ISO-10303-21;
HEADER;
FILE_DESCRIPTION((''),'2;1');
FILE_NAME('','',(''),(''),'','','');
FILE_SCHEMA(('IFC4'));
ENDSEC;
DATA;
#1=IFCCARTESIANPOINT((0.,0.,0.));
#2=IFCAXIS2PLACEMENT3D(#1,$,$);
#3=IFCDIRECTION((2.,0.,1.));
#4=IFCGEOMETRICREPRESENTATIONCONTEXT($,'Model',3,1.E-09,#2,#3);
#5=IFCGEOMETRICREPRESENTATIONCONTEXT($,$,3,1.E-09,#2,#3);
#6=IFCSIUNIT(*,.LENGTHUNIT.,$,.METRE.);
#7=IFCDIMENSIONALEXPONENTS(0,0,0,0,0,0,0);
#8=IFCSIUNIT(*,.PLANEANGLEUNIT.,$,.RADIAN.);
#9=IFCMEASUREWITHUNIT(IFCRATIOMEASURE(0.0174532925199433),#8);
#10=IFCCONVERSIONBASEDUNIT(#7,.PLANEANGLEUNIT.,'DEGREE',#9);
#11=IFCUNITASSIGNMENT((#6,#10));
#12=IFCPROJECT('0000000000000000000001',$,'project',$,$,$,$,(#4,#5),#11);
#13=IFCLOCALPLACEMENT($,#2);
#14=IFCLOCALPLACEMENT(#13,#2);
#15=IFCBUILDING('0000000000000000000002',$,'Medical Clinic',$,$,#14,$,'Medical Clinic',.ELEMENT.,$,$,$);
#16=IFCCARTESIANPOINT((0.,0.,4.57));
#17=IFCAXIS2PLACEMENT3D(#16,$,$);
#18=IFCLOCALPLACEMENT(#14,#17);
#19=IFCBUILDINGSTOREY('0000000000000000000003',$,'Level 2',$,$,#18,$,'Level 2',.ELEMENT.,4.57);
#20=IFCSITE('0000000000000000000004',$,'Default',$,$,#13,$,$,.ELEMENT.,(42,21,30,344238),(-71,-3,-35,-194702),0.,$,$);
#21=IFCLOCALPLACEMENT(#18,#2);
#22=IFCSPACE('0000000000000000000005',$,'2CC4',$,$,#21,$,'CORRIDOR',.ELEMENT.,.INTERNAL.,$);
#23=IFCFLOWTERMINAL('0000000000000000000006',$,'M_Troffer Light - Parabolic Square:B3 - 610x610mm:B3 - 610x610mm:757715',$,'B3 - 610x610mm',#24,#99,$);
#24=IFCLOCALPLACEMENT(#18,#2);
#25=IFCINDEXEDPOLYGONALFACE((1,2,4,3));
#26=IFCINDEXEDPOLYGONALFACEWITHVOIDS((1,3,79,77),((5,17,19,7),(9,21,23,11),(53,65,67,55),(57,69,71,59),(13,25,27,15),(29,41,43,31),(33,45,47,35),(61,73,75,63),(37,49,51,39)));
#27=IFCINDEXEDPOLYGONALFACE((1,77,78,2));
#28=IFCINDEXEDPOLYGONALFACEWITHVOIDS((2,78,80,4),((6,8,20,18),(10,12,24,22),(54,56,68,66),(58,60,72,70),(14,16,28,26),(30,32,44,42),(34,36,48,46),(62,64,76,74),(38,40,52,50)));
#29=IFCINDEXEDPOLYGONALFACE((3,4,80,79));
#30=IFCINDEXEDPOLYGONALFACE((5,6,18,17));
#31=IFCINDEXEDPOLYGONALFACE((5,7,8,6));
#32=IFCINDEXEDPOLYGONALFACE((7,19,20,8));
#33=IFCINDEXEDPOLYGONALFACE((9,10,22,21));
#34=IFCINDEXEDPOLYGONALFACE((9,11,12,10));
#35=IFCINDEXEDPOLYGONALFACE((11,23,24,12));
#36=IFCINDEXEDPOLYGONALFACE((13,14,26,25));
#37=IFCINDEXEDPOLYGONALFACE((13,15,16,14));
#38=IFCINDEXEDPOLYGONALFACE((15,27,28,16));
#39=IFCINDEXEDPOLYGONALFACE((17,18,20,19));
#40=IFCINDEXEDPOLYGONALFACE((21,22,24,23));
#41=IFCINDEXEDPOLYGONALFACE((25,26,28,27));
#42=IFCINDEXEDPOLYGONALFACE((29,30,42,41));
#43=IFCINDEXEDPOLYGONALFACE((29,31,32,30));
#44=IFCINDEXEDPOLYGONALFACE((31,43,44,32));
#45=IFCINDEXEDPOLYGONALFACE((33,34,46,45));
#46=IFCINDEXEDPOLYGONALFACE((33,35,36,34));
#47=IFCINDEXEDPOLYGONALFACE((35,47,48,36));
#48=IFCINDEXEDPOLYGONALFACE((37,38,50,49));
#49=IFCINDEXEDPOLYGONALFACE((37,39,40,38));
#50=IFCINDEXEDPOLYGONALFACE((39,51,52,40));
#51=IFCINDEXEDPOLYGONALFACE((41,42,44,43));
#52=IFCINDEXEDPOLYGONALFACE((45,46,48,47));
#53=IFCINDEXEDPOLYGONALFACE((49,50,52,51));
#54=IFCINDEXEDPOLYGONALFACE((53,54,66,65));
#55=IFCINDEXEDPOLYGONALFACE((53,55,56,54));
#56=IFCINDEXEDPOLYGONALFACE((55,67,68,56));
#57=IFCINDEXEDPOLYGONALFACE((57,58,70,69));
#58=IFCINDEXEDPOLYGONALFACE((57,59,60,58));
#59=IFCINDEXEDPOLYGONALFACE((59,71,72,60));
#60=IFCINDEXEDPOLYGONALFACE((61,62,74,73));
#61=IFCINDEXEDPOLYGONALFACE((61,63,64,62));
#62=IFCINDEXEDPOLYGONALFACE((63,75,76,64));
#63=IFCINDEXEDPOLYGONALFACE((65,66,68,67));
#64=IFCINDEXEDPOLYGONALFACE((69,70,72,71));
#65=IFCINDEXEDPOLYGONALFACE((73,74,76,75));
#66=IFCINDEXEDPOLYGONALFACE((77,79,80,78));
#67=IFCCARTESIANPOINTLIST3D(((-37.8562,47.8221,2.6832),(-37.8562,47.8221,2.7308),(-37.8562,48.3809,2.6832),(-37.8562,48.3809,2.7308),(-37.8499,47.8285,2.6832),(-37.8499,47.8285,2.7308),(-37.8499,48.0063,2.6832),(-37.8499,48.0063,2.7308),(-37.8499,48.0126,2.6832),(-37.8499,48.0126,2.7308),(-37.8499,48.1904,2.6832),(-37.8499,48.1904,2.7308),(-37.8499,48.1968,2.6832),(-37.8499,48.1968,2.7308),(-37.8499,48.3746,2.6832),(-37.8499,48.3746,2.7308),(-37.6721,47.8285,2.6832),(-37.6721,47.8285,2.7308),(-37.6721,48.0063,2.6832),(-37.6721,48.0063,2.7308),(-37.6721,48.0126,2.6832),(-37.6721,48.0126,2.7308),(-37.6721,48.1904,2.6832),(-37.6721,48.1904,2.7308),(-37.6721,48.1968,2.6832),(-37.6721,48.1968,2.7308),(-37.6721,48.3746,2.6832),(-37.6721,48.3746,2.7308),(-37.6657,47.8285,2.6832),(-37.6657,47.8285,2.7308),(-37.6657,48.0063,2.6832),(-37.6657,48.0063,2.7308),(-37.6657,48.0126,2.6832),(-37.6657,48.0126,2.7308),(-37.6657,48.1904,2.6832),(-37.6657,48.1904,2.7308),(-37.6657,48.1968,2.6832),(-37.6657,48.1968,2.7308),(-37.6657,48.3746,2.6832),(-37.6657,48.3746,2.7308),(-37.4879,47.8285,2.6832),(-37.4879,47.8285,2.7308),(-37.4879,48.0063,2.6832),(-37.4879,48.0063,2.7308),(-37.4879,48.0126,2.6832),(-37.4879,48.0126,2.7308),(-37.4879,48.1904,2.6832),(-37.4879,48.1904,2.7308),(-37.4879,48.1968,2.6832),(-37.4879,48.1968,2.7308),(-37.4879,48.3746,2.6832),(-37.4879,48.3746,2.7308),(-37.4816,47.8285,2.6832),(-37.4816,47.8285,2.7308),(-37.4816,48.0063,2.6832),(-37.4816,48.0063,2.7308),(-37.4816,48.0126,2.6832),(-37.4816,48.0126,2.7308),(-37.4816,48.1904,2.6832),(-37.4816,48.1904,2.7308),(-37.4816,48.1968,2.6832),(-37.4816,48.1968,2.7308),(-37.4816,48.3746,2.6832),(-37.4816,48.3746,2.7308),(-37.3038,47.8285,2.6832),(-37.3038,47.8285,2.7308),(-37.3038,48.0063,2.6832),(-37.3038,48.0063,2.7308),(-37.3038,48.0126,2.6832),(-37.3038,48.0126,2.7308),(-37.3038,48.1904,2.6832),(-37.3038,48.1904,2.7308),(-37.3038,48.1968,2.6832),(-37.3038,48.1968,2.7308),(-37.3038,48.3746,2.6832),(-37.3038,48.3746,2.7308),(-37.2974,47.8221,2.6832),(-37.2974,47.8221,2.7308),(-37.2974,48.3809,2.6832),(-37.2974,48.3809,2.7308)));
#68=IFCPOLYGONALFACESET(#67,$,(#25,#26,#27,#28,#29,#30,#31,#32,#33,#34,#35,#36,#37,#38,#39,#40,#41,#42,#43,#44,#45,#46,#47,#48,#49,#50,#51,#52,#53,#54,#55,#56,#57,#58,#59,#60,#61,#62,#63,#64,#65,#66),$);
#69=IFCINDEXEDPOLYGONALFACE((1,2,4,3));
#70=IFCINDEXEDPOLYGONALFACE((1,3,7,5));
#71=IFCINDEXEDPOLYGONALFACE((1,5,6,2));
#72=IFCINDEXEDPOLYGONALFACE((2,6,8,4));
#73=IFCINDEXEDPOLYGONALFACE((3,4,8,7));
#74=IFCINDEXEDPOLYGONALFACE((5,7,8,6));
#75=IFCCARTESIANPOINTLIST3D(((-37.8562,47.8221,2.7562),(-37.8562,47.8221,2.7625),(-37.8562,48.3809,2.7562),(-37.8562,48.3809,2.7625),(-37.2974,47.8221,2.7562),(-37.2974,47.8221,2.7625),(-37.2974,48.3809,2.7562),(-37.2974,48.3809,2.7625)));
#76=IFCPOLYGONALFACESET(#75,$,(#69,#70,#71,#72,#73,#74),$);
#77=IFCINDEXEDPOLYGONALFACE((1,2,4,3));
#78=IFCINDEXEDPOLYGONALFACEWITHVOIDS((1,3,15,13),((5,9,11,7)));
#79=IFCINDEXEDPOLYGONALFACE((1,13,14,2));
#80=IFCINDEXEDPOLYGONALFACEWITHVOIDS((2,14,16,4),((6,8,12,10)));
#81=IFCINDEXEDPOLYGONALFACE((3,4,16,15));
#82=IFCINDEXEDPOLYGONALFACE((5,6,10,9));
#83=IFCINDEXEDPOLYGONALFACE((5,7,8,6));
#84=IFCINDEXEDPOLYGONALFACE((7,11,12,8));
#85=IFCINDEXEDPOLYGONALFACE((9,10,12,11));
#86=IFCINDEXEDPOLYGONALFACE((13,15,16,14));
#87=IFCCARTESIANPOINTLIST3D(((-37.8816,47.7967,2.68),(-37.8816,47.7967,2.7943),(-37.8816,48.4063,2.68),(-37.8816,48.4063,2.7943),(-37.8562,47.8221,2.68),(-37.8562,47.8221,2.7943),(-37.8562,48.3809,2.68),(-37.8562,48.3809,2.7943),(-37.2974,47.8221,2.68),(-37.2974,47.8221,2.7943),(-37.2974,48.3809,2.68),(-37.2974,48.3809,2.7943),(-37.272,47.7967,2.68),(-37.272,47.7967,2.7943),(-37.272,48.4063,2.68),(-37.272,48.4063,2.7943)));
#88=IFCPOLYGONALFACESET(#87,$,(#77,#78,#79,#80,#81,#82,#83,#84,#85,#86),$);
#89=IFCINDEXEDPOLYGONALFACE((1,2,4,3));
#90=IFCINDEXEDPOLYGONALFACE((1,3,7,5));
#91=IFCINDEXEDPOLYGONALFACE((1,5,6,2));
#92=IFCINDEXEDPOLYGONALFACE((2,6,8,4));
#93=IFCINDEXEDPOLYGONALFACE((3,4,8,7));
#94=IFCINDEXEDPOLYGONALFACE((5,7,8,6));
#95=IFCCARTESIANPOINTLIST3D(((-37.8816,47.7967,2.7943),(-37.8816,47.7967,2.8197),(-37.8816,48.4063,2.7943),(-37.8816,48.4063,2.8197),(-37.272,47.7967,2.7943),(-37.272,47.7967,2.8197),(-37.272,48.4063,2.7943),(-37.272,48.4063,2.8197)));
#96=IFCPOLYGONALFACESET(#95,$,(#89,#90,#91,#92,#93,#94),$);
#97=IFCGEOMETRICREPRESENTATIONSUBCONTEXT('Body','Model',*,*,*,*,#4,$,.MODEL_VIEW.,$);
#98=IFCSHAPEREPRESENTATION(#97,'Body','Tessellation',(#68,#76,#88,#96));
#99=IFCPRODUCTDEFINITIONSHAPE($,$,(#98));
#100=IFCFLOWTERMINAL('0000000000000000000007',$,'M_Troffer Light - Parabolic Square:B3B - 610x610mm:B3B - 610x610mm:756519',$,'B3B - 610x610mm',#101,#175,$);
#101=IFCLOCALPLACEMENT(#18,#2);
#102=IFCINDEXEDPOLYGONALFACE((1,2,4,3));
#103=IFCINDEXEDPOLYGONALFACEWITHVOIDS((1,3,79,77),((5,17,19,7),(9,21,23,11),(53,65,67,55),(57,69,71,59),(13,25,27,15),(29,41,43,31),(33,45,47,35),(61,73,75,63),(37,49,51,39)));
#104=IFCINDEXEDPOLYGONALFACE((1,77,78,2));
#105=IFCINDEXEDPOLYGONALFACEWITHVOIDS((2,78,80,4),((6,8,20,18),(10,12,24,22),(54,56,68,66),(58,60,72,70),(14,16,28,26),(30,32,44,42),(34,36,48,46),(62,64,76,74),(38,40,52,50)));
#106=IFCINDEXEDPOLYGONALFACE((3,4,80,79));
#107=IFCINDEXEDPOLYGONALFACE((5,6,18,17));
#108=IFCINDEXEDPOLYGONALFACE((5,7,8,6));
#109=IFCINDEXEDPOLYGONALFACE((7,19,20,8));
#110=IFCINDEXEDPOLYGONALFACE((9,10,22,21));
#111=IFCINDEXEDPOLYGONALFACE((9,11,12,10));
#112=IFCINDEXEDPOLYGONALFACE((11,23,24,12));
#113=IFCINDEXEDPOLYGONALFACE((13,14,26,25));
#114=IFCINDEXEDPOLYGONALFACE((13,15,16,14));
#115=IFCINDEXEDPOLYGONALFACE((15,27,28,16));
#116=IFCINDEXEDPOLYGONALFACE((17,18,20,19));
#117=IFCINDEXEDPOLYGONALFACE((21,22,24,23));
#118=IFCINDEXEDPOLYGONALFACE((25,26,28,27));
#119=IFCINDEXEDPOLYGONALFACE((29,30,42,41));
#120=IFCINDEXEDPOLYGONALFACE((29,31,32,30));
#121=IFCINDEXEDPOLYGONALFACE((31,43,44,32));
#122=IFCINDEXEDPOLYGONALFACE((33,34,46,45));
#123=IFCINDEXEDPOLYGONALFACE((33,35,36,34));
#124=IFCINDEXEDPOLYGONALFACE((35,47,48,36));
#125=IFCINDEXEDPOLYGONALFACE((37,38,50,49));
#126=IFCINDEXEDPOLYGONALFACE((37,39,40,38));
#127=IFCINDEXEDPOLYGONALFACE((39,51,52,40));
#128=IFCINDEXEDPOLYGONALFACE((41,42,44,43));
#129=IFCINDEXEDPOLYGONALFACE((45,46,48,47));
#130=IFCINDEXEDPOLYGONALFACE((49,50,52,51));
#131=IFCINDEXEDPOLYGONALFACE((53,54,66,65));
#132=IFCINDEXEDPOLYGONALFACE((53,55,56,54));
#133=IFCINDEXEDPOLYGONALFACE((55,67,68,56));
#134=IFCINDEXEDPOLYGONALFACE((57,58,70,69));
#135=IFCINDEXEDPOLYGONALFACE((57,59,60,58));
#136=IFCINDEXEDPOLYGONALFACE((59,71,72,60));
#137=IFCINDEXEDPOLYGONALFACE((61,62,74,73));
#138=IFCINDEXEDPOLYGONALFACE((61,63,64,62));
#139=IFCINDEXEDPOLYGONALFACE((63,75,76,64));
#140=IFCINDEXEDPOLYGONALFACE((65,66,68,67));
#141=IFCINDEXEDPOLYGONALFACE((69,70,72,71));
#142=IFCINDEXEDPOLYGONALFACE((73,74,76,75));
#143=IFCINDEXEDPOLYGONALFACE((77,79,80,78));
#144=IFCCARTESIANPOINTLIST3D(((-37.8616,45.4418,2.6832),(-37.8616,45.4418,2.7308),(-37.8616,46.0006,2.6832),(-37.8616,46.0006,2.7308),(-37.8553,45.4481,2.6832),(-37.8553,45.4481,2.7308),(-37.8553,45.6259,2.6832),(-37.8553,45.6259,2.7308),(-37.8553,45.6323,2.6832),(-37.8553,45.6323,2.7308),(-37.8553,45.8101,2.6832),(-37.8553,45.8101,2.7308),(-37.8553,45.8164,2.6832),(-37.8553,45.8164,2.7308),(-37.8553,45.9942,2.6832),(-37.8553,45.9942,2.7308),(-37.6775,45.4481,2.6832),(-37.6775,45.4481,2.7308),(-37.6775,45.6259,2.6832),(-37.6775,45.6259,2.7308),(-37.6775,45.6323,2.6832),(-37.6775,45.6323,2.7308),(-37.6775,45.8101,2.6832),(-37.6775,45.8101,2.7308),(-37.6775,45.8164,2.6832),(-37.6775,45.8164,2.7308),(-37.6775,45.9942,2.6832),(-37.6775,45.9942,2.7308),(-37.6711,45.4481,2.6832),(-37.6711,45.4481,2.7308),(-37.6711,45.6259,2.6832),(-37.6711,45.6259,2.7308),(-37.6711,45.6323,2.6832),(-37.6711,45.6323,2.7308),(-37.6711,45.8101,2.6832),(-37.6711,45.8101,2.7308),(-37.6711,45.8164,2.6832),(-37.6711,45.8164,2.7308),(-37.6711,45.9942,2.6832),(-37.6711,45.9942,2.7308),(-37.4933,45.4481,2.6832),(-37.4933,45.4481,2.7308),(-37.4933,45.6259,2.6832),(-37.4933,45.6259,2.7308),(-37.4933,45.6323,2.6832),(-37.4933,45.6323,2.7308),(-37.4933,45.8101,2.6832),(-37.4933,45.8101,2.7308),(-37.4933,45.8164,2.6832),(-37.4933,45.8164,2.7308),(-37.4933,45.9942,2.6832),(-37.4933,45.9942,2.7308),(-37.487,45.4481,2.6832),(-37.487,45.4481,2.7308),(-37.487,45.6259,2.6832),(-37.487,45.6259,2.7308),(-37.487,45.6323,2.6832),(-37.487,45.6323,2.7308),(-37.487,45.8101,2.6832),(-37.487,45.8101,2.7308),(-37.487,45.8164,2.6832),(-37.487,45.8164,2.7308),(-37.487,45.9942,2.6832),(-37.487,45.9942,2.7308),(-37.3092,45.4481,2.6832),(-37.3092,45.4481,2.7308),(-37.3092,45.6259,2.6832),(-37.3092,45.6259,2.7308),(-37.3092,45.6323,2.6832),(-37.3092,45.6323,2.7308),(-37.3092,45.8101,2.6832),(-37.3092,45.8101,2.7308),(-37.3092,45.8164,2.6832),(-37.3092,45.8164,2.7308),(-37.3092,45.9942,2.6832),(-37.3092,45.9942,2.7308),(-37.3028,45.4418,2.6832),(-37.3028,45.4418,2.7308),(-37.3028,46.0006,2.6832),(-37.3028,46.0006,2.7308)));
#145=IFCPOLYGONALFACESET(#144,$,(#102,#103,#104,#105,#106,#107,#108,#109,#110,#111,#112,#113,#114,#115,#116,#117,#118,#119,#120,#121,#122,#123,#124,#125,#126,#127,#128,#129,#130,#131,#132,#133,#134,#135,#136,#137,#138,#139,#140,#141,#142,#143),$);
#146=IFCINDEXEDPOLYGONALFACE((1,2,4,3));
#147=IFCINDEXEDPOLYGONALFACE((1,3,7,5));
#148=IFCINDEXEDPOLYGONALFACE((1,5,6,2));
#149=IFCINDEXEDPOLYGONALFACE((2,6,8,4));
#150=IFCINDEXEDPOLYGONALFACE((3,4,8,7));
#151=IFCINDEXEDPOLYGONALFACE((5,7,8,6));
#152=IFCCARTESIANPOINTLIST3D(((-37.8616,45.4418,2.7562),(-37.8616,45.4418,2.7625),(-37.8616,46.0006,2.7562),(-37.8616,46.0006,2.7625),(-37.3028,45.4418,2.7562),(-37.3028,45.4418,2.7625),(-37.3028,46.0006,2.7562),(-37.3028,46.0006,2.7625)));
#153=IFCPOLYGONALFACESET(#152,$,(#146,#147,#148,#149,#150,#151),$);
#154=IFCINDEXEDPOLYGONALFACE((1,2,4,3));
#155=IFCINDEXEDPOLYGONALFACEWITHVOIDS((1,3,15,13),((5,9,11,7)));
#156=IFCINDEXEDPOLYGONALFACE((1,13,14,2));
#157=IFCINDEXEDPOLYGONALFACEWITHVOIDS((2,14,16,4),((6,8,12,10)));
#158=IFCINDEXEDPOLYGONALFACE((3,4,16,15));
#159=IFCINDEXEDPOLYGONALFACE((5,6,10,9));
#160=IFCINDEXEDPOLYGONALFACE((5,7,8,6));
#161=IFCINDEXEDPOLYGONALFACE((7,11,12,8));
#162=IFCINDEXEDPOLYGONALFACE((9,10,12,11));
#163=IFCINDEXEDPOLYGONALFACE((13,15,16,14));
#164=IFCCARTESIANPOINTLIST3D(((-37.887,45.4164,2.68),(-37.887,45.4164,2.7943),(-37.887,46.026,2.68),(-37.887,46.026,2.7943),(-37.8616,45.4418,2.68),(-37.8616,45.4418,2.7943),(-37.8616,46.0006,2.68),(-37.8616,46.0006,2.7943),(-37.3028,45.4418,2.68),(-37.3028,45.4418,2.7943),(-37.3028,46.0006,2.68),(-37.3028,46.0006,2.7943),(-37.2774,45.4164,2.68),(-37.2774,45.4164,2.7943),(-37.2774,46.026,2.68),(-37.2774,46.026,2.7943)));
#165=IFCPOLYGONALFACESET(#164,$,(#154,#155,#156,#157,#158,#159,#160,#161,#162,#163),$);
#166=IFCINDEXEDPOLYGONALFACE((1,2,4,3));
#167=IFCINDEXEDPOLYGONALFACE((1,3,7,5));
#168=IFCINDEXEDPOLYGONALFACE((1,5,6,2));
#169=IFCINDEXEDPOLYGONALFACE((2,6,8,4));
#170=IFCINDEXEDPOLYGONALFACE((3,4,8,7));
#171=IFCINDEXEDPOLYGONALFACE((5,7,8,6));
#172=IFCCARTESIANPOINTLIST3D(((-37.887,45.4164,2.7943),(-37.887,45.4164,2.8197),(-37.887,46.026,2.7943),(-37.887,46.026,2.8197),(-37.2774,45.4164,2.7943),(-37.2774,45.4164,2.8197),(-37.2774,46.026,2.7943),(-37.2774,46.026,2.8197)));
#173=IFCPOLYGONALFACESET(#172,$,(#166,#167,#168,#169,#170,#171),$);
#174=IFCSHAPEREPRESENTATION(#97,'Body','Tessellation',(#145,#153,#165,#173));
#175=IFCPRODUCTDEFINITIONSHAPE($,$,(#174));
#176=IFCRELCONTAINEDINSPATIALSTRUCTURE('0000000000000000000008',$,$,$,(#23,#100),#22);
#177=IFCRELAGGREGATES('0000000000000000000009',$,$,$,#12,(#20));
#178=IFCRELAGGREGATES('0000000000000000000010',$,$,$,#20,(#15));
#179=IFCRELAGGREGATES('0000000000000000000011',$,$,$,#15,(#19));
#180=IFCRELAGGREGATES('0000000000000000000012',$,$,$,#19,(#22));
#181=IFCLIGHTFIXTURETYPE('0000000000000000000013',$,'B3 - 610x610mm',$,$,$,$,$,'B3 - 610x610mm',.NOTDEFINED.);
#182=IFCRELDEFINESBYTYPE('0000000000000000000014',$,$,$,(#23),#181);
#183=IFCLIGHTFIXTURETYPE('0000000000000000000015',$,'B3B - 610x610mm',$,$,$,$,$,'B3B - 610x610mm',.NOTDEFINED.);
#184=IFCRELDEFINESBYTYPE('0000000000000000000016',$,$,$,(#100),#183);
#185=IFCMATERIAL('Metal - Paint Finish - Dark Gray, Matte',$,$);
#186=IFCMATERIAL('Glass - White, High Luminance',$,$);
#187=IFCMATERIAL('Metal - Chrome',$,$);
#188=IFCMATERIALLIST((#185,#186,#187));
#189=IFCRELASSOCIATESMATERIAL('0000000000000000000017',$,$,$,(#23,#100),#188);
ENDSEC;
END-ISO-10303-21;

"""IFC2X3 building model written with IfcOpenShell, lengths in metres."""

from ifc_helpers import new_model, entity, si_unit, converted_unit, direction, frame, origin, origin_2d_with_axis, place, context, subcontext, project, spatial, polyline, rectangle, outline, extrude, source, transform, mapped, material, material_list, type_object, type_shapes, element, save


model = new_model("IFC2X3")

# Units and contexts
model_context = context("Model", 3, precision=1e-09, world=origin(), true_north=direction((2.0, 0.0, 1.0)))
context_of_model = context(None, 3, precision=1e-09, world=origin(), true_north=direction((2.0, 0.0, 1.0)))
body_context = subcontext(model_context, "Body", "Model", "MODEL_VIEW")
ifc_project = project(units=[si_unit("LENGTHUNIT", "METRE"), converted_unit("PLANEANGLEUNIT", "DEGREE", entity("IfcRatioMeasure", 0.0174532925199433), si_unit("PLANEANGLEUNIT", "RADIAN"), dimensions=[0, 0, 0, 0, 0, 0, 0])], contexts=[model_context, context_of_model])

# Site, building, storey
site_placement = place(None, origin())
site = spatial("IfcSite", under=ifc_project, at=site_placement, Name="Default", CompositionType="ELEMENT", RefLatitude=(42, 21, 30, 344238), RefLongitude=(-71, -3, -35, -194702), RefElevation=0.0)
building_placement = place(site_placement, origin())
building = spatial("IfcBuilding", under=site, at=building_placement, Name="Medical Clinic", LongName="Medical Clinic", CompositionType="ELEMENT")
storey_placement = place(building_placement, frame((0.0, 0.0, 4.57)))
storey = spatial("IfcBuildingStorey", under=building, at=storey_placement, Name="Level 2", LongName="Level 2", CompositionType="ELEMENT", Elevation=4.57)

# Shared definitions
space_1_placement = place(storey_placement, origin())
space_1 = spatial("IfcSpace", under=storey, at=space_1_placement, Name="2CC4", LongName="CORRIDOR", CompositionType="ELEMENT", InteriorOrExteriorSpace="INTERNAL")

# Flow terminals
ifc_material_1 = material(Name="Metal - Paint Finish - Dark Gray, Matte")
ifc_material_2 = material(Name="Glass - White, High Luminance")
ifc_material_3 = material(Name="Metal - Chrome")
ifc_material_list_1 = material_list([ifc_material_1, ifc_material_2, ifc_material_3])
light_fixture_type_1 = type_object("IfcLightFixtureType", Name="B3 - 610x610mm", ElementType="B3 - 610x610mm", PredefinedType="NOTDEFINED")
shared_shape_1 = source(origin(), body_context, "Body", "SweptSolid", [
    extrude(outline(polyline([(-0.2794, -0.2794), (0.2794, -0.2794), (0.2794, 0.2794), (-0.2794, 0.2794), (-0.2794, -0.2794)]), holes=[polyline([(-0.0952, 0.0953), (-0.273, 0.0953), (-0.273, 0.2731), (-0.0952, 0.2731), (-0.0952, 0.0953)]), polyline([(0.2731, 0.0953), (0.0953, 0.0953), (0.0953, 0.2731), (0.2731, 0.2731), (0.2731, 0.0953)]), polyline([(-0.0889, 0.2731), (0.0889, 0.2731), (0.0889, 0.0953), (-0.0889, 0.0953), (-0.0889, 0.2731)]), polyline([(0.2731, -0.273), (0.0953, -0.273), (0.0953, -0.0952), (0.2731, -0.0952), (0.2731, -0.273)]), polyline([(0.0889, -0.273), (-0.0889, -0.273), (-0.0889, -0.0952), (0.0889, -0.0952), (0.0889, -0.273)]), polyline([(-0.0952, -0.273), (-0.273, -0.273), (-0.273, -0.0952), (-0.0952, -0.0952), (-0.0952, -0.273)]), polyline([(-0.0952, -0.0889), (-0.273, -0.0889), (-0.273, 0.0889), (-0.0952, 0.0889), (-0.0952, -0.0889)]), polyline([(0.0889, -0.0889), (-0.0889, -0.0889), (-0.0889, 0.0889), (0.0889, 0.0889), (0.0889, -0.0889)]), polyline([(0.2731, -0.0889), (0.0953, -0.0889), (0.0953, 0.0889), (0.2731, 0.0889), (0.2731, -0.0889)])]), frame((0.0, -0.3048, -0.0508), z_axis=(0.0, 0.0, 1.0), x_axis=(-1.0, 0.0, 0.0)), (0.0, 0.0, 1.0), 0.0476),
    extrude(rectangle(XDim=0.5588, YDim=0.5588, at=origin_2d_with_axis()), frame((0.0, -0.3048, -0.0825), z_axis=(0.0, 0.0, 1.0), x_axis=(-1.0, 0.0, 0.0)), (0.0, 0.0, 1.0), 0.0064),
    extrude(outline(polyline([(-0.3048, -0.3048), (0.3048, -0.3048), (0.3048, 0.3048), (-0.3048, 0.3048), (-0.3048, -0.3048)]), holes=[polyline([(0.2794, 0.2794), (0.2794, -0.2794), (-0.2794, -0.2794), (-0.2794, 0.2794), (0.2794, 0.2794)])]), frame((0.0, -0.3048, -0.1143)), (0.0, 0.0, 1.0), 0.1143),
    extrude(rectangle(XDim=0.6096, YDim=0.6096, at=origin_2d_with_axis()), frame((0.0, -0.3048, -0.1397), z_axis=(0.0, 0.0, 1.0), x_axis=(-1.0, 0.0, 0.0)), (0.0, 0.0, 1.0), 0.0254),
])
type_shapes(light_fixture_type_1, [shared_shape_1])
flow_terminal_1_placement = place(space_1_placement, frame((-37.5768, 47.7967, 2.68), z_axis=(0.0, 0.0, -1.0), x_axis=(1.0, 0.0, 0.0)))
element("IfcFlowTerminal", 1, at=flow_terminal_1_placement, inside=space_1, type_object=light_fixture_type_1, material=ifc_material_list_1, Name="M_Troffer Light - Parabolic Square:B3 - 610x610mm:B3 - 610x610mm:757715", ObjectType="B3 - 610x610mm", context=body_context, shape_type="MappedRepresentation", body=[
    mapped(shared_shape_1, transform((0.0, 0.0, 0.0), scale=1.0)),
])
light_fixture_type_2 = type_object("IfcLightFixtureType", Name="B3B - 610x610mm", ElementType="B3B - 610x610mm", PredefinedType="NOTDEFINED")
shared_shape_2 = source(origin(), body_context, "Body", "SweptSolid", [
    extrude(outline(polyline([(-0.2794, -0.2794), (0.2794, -0.2794), (0.2794, 0.2794), (-0.2794, 0.2794), (-0.2794, -0.2794)]), holes=[polyline([(-0.0952, 0.0953), (-0.273, 0.0953), (-0.273, 0.2731), (-0.0952, 0.2731), (-0.0952, 0.0953)]), polyline([(0.2731, 0.0953), (0.0953, 0.0953), (0.0953, 0.2731), (0.2731, 0.2731), (0.2731, 0.0953)]), polyline([(-0.0889, 0.2731), (0.0889, 0.2731), (0.0889, 0.0953), (-0.0889, 0.0953), (-0.0889, 0.2731)]), polyline([(0.2731, -0.273), (0.0953, -0.273), (0.0953, -0.0952), (0.2731, -0.0952), (0.2731, -0.273)]), polyline([(0.0889, -0.273), (-0.0889, -0.273), (-0.0889, -0.0952), (0.0889, -0.0952), (0.0889, -0.273)]), polyline([(-0.0952, -0.273), (-0.273, -0.273), (-0.273, -0.0952), (-0.0952, -0.0952), (-0.0952, -0.273)]), polyline([(-0.0952, -0.0889), (-0.273, -0.0889), (-0.273, 0.0889), (-0.0952, 0.0889), (-0.0952, -0.0889)]), polyline([(0.0889, -0.0889), (-0.0889, -0.0889), (-0.0889, 0.0889), (0.0889, 0.0889), (0.0889, -0.0889)]), polyline([(0.2731, -0.0889), (0.0953, -0.0889), (0.0953, 0.0889), (0.2731, 0.0889), (0.2731, -0.0889)])]), frame((0.0, -0.3048, -0.0508), z_axis=(0.0, 0.0, 1.0), x_axis=(-1.0, 0.0, 0.0)), (0.0, 0.0, 1.0), 0.0476),
    extrude(rectangle(XDim=0.5588, YDim=0.5588, at=origin_2d_with_axis()), frame((0.0, -0.3048, -0.0825), z_axis=(0.0, 0.0, 1.0), x_axis=(-1.0, 0.0, 0.0)), (0.0, 0.0, 1.0), 0.0064),
    extrude(outline(polyline([(-0.3048, -0.3048), (0.3048, -0.3048), (0.3048, 0.3048), (-0.3048, 0.3048), (-0.3048, -0.3048)]), holes=[polyline([(0.2794, 0.2794), (0.2794, -0.2794), (-0.2794, -0.2794), (-0.2794, 0.2794), (0.2794, 0.2794)])]), frame((0.0, -0.3048, -0.1143)), (0.0, 0.0, 1.0), 0.1143),
    extrude(rectangle(XDim=0.6096, YDim=0.6096, at=origin_2d_with_axis()), frame((0.0, -0.3048, -0.1397), z_axis=(0.0, 0.0, 1.0), x_axis=(-1.0, 0.0, 0.0)), (0.0, 0.0, 1.0), 0.0254),
])
type_shapes(light_fixture_type_2, [shared_shape_2])
flow_terminal_2_placement = place(space_1_placement, frame((-37.5822, 45.4164, 2.68), z_axis=(0.0, 0.0, -1.0), x_axis=(1.0, 0.0, 0.0)))
element("IfcFlowTerminal", 2, at=flow_terminal_2_placement, inside=space_1, type_object=light_fixture_type_2, material=ifc_material_list_1, Name="M_Troffer Light - Parabolic Square:B3B - 610x610mm:B3B - 610x610mm:756519", ObjectType="B3B - 610x610mm", context=body_context, shape_type="MappedRepresentation", body=[
    mapped(shared_shape_2, transform((0.0, 0.0, 0.0), scale=1.0)),
])

save(model, "model.ifc")
